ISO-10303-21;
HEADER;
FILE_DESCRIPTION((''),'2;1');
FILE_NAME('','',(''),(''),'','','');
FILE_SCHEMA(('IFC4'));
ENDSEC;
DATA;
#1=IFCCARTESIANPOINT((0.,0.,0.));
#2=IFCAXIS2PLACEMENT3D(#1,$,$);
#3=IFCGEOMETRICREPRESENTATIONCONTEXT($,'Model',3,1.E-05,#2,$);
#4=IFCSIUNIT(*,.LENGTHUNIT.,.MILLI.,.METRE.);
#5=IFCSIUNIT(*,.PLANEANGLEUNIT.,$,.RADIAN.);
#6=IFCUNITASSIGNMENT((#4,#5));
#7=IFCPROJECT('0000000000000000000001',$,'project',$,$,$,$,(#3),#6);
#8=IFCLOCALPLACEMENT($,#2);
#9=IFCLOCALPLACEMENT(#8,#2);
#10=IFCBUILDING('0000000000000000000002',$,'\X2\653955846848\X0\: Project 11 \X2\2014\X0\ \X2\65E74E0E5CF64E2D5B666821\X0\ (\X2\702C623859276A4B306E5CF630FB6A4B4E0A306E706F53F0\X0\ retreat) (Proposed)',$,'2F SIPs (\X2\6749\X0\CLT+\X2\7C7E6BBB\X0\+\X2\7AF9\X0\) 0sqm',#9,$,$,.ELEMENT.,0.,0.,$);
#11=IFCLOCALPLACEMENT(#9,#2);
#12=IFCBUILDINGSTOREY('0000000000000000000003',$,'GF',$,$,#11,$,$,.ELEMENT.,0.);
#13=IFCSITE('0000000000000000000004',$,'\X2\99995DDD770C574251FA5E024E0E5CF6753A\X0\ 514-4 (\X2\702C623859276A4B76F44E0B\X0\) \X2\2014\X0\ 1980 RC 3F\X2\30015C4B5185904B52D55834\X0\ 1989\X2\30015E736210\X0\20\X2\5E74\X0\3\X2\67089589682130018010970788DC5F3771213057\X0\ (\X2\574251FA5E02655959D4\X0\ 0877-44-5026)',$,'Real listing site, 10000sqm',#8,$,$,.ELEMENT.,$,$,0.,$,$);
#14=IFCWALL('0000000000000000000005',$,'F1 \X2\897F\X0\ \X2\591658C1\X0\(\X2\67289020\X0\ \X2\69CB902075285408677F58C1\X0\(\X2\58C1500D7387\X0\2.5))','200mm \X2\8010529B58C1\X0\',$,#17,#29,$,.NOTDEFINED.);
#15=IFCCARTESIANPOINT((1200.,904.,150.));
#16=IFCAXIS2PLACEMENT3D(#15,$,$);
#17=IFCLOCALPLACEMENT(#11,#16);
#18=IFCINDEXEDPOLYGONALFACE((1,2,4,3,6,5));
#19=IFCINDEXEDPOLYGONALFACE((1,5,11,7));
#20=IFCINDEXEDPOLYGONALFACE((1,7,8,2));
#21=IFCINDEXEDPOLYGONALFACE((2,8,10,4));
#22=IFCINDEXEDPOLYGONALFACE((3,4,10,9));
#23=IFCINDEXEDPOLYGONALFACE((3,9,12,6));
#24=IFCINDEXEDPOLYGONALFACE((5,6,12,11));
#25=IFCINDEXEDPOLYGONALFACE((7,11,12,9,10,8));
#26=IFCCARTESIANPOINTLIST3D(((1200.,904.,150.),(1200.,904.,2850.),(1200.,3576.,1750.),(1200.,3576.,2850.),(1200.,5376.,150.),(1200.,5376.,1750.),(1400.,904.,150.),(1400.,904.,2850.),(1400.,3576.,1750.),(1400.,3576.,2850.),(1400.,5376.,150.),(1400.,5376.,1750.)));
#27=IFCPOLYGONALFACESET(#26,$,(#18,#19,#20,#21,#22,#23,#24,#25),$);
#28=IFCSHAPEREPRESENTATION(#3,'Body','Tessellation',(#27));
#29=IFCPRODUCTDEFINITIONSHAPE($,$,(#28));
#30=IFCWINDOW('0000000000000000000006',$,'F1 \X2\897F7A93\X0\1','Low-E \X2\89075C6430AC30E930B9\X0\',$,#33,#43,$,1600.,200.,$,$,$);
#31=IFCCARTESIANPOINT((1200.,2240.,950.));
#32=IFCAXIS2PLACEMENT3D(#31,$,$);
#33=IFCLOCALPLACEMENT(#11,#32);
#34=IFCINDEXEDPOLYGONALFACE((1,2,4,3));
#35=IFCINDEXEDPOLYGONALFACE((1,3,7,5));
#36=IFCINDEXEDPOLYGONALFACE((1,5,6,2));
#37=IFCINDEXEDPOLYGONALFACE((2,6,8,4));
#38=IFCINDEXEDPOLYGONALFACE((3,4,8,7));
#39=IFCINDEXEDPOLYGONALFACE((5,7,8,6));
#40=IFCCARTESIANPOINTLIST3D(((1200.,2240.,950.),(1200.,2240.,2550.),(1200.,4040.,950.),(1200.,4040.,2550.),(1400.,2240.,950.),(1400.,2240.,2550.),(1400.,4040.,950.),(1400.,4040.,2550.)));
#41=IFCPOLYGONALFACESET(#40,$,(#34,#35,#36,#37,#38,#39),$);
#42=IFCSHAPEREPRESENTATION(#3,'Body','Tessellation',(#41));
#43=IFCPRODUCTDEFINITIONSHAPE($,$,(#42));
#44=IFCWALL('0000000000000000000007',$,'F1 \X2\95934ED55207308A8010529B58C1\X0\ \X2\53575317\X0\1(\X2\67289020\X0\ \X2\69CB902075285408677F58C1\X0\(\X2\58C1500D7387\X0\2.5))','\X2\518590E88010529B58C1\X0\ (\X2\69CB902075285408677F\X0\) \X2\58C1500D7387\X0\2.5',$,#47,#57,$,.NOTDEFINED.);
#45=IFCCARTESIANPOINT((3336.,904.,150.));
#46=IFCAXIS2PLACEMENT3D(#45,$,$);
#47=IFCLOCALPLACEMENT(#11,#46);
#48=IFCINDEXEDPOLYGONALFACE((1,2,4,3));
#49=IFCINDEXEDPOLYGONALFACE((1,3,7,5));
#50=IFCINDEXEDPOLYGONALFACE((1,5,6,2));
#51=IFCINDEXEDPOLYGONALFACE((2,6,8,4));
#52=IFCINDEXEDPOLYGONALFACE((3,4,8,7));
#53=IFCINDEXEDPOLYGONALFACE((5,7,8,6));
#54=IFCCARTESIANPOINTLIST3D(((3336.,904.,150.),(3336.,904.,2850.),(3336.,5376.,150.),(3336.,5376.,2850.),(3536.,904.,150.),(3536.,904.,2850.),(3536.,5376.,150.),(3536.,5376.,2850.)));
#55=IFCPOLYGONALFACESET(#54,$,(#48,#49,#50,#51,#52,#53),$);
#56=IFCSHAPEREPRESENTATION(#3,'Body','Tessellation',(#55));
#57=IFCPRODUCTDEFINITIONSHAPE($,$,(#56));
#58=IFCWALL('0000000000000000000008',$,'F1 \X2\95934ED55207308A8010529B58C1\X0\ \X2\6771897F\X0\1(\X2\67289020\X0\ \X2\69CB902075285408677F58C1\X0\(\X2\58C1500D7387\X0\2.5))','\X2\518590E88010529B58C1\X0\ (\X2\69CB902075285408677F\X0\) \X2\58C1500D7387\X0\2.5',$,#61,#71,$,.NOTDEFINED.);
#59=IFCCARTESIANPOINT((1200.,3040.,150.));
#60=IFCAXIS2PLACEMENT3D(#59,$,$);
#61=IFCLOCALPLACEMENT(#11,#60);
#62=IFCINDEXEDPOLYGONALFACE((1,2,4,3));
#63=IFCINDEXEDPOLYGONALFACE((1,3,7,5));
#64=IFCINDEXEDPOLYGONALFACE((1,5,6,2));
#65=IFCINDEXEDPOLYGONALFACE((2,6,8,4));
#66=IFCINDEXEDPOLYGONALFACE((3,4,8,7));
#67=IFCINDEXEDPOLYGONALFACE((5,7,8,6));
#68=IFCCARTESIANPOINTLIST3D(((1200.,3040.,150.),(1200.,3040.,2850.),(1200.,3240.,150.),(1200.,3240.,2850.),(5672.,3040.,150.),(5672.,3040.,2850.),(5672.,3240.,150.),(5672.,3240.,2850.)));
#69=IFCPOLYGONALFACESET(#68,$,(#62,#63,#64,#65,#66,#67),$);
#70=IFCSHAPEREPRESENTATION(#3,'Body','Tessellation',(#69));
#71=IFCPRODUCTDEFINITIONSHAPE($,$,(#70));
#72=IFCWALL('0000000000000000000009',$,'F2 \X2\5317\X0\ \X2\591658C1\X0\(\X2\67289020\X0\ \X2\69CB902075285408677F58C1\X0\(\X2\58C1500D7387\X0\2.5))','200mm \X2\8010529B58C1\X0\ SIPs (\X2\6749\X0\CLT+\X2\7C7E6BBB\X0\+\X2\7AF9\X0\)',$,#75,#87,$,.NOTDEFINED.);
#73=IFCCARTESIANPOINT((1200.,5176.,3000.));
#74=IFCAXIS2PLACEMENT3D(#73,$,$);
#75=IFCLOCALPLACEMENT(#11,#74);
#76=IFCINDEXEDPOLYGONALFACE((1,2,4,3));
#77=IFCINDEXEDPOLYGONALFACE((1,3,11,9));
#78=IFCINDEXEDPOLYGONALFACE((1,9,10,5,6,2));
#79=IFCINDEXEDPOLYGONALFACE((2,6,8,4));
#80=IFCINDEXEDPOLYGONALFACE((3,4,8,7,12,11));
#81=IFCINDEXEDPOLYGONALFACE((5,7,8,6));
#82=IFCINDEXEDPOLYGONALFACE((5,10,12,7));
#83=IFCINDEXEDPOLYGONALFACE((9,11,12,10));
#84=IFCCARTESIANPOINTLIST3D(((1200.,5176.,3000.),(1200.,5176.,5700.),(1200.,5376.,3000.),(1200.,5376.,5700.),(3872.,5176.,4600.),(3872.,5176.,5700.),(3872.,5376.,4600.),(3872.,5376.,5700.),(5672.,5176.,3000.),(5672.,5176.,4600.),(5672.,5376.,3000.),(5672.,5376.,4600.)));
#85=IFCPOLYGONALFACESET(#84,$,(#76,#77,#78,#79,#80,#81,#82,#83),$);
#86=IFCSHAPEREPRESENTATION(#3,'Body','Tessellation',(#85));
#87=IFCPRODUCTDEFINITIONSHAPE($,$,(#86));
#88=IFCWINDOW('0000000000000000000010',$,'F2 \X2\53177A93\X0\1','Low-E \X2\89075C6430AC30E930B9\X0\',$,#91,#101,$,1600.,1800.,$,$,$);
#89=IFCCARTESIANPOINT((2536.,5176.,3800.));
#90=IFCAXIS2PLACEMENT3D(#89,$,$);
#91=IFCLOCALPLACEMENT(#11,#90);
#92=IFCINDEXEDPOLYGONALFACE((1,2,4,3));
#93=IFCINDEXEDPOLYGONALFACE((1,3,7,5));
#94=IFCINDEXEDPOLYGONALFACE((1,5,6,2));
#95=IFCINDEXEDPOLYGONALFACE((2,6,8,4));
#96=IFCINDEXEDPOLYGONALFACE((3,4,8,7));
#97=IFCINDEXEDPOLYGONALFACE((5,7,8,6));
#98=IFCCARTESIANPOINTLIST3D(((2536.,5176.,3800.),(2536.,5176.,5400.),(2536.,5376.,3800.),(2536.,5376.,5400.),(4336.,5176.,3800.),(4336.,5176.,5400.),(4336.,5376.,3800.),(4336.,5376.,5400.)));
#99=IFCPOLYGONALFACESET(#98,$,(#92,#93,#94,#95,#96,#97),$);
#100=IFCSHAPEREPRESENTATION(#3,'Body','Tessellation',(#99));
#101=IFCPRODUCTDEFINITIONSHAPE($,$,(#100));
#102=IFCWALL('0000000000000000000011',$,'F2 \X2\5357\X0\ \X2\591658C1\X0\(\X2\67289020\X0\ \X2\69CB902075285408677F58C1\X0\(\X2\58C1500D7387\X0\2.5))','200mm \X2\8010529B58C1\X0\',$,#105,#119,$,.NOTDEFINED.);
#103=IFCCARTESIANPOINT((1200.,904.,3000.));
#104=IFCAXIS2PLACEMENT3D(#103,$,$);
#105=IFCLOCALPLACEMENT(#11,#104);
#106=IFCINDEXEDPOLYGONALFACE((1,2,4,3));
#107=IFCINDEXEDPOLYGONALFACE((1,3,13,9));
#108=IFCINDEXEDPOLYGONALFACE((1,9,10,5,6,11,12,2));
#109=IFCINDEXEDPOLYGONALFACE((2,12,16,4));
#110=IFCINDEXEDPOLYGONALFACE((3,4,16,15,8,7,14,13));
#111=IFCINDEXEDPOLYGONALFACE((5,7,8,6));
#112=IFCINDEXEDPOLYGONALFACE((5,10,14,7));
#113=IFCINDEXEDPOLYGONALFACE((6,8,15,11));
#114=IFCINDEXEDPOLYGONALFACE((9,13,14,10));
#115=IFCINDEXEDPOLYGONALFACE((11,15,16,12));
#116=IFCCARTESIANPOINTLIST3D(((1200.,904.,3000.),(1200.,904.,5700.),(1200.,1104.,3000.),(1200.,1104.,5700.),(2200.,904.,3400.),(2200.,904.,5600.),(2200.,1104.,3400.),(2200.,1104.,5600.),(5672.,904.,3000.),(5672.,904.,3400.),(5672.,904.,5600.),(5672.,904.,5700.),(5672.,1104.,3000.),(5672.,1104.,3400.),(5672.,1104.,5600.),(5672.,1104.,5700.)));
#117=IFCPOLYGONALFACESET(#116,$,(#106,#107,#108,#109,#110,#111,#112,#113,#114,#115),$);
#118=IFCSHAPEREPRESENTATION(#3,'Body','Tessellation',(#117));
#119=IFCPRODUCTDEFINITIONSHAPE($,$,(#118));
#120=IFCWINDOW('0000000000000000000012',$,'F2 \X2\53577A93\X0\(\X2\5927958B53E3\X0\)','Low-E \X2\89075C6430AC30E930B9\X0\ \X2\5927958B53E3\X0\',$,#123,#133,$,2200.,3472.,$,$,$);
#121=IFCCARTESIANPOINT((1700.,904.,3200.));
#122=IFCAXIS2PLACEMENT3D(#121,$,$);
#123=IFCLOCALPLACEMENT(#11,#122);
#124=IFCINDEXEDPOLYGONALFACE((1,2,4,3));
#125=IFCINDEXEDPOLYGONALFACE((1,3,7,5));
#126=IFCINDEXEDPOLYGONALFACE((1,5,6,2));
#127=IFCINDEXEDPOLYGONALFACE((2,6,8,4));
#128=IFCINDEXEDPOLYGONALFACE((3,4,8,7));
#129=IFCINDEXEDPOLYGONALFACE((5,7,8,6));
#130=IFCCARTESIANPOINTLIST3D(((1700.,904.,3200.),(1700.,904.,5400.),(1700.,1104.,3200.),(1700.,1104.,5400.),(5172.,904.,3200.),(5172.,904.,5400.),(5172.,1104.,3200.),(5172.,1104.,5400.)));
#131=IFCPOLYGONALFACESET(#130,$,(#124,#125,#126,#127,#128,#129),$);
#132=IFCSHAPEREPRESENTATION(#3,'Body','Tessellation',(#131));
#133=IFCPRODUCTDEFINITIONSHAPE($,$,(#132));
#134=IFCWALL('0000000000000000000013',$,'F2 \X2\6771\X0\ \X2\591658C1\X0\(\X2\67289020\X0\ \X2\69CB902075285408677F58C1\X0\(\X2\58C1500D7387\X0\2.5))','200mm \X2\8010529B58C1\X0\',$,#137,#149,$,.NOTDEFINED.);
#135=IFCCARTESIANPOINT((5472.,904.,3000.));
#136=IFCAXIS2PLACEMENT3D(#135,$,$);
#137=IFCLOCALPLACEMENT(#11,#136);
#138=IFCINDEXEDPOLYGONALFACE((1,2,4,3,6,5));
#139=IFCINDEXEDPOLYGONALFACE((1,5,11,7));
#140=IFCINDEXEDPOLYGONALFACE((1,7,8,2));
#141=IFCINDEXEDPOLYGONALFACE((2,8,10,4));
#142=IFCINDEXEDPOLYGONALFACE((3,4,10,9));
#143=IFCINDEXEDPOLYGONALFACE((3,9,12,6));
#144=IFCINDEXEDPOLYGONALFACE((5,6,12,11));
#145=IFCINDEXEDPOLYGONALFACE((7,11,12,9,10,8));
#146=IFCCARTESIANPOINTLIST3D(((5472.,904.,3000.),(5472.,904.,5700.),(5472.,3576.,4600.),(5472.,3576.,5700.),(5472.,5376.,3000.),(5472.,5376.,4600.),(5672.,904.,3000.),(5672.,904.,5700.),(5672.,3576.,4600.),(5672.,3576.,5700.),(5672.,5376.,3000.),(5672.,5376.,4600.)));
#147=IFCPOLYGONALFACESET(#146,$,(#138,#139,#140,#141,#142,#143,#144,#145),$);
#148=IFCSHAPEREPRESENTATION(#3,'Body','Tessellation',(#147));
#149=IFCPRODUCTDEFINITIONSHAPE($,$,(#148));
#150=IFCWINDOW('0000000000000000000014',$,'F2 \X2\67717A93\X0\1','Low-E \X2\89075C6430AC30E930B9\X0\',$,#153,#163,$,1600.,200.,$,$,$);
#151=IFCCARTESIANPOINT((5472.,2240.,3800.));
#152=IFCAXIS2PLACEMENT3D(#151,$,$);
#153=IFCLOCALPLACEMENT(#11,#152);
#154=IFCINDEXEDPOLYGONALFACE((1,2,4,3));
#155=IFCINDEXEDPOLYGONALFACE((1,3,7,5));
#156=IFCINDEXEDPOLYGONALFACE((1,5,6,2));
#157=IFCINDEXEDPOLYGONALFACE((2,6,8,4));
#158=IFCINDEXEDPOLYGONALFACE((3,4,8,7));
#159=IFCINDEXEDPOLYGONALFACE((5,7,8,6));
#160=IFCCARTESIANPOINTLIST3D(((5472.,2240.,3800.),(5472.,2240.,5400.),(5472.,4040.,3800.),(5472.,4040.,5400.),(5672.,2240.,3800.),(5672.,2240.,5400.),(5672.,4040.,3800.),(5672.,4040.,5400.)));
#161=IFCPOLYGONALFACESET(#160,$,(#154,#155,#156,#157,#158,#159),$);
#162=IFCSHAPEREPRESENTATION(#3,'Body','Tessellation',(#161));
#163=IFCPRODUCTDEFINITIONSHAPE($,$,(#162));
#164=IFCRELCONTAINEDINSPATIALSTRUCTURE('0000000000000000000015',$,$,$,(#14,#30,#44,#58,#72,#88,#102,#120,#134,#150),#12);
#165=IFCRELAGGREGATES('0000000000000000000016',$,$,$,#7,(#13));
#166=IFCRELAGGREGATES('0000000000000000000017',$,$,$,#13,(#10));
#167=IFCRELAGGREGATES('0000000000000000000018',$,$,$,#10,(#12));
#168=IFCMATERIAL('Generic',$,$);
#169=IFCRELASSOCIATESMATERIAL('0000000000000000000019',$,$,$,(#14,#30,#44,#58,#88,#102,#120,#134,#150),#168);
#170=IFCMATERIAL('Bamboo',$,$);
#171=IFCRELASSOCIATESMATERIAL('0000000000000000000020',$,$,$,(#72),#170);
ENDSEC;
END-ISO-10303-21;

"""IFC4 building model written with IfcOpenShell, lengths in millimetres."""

from ifc_helpers import new_model, si_unit, frame, frame_2d, origin, place, context, project, spatial, rectangle, extrude, material, element, fill, save


model = new_model("IFC4")

# Units and contexts
model_context = context("Model", 3, precision=1e-05, world=origin())
ifc_project = project(units=[si_unit("LENGTHUNIT", "METRE", prefix="MILLI"), si_unit("PLANEANGLEUNIT", "RADIAN")], contexts=[model_context])

# Site, building, storey
site_placement = place(None, origin())
site = spatial("IfcSite", under=ifc_project, at=site_placement, Name="香川県坂出市与島町 514-4 (瀬戸大橋直下) — 1980 RC 3F、屋内運動場 1989、平成20年3月閉校、耐震補強無し (坂出市教委 0877-44-5026)", ObjectType="Real listing site, 10000sqm", CompositionType="ELEMENT", RefElevation=0.0)
building_placement = place(site_placement, origin())
building = spatial("IfcBuilding", under=site, at=building_placement, Name="改善案: Project 11 — 旧与島中学校 (瀬戸大橋の島・橋上の灯台 retreat) (Proposed)", ObjectType="2F SIPs (杉CLT+籾殻+竹) 0sqm", CompositionType="ELEMENT", ElevationOfRefHeight=0.0, ElevationOfTerrain=0.0)
storey_placement = place(building_placement, origin())
storey = spatial("IfcBuildingStorey", under=building, at=storey_placement, Name="GF", CompositionType="ELEMENT", Elevation=0.0)

# Shared definitions
ifc_material_1 = material(Name="Generic")

# Shared definitions
ifc_material_2 = material(Name="Bamboo")

# Wall, opening, window
wall_1_placement = place(storey_placement, frame((1200.0, 904.0, 150.0)))
wall_1 = element("IfcWall", 1, at=wall_1_placement, inside=storey, material=ifc_material_1, Name="F1 西 外壁(木造 構造用合板壁(壁倍率2.5))", Description="200mm 耐力壁", PredefinedType="NOTDEFINED", context=model_context, shape_type="SweptSolid", body=[
    extrude(rectangle(XDim=200.0, YDim=4472.0, at=frame_2d((100.0, 2236.0))), frame((1200.0, 904.0, 150.0)), (0.0, 0.0, 1.0), 2700.0),
])
opening_1_placement = place(storey_placement, frame((1200.0, 2240.0, 950.0)))
opening_1 = element("IfcOpeningElement", 2, at=opening_1_placement, cuts=wall_1, PredefinedType="NOTDEFINED", context=model_context, shape_type="SweptSolid", body=[
    extrude(rectangle(XDim=200.0, YDim=1800.0, at=frame_2d((100.0, 900.0))), frame((1200.0, 2240.0, 950.0)), (0.0, 0.0, 1.0), 1600.0),
])
window_1_placement = place(storey_placement, frame((1200.0, 2240.0, 950.0)))
window_1 = element("IfcWindow", 3, at=window_1_placement, inside=storey, material=ifc_material_1, Name="F1 西窓1", Description="Low-E 複層ガラス", OverallHeight=1600.0, OverallWidth=200.0, context=model_context, shape_type="SweptSolid", body=[
    extrude(rectangle(XDim=200.0, YDim=1800.0, at=frame_2d((100.0, 900.0))), frame((1200.0, 2240.0, 950.0)), (0.0, 0.0, 1.0), 1600.0),
])
fill(opening_1, window_1)

# Walls
wall_2_placement = place(storey_placement, frame((3336.0, 904.0, 150.0)))
element("IfcWall", 4, at=wall_2_placement, inside=storey, material=ifc_material_1, Name="F1 間仕切り耐力壁 南北1(木造 構造用合板壁(壁倍率2.5))", Description="内部耐力壁 (構造用合板) 壁倍率2.5", PredefinedType="NOTDEFINED", context=model_context, shape_type="SweptSolid", body=[
    extrude(rectangle(XDim=200.0, YDim=4472.0, at=frame_2d((100.0, 2236.0))), frame((3336.0, 904.0, 150.0)), (0.0, 0.0, 1.0), 2700.0),
])
wall_3_placement = place(storey_placement, frame((1200.0, 3040.0, 150.0)))
element("IfcWall", 5, at=wall_3_placement, inside=storey, material=ifc_material_1, Name="F1 間仕切り耐力壁 東西1(木造 構造用合板壁(壁倍率2.5))", Description="内部耐力壁 (構造用合板) 壁倍率2.5", PredefinedType="NOTDEFINED", context=model_context, shape_type="SweptSolid", body=[
    extrude(rectangle(XDim=4472.0, YDim=200.0, at=frame_2d((2236.0, 100.0))), frame((1200.0, 3040.0, 150.0)), (0.0, 0.0, 1.0), 2700.0),
])

# Walls, openings, windows
wall_4_placement = place(storey_placement, frame((1200.0, 5176.0, 3000.0)))
wall_4 = element("IfcWall", 6, at=wall_4_placement, inside=storey, material=ifc_material_2, Name="F2 北 外壁(木造 構造用合板壁(壁倍率2.5))", Description="200mm 耐力壁 SIPs (杉CLT+籾殻+竹)", PredefinedType="NOTDEFINED", context=model_context, shape_type="SweptSolid", body=[
    extrude(rectangle(XDim=4472.0, YDim=200.0, at=frame_2d((2236.0, 100.0))), frame((1200.0, 5176.0, 3000.0)), (0.0, 0.0, 1.0), 2700.0),
])
opening_2_placement = place(storey_placement, frame((2536.0, 5176.0, 3800.0)))
opening_2 = element("IfcOpeningElement", 7, at=opening_2_placement, cuts=wall_4, PredefinedType="NOTDEFINED", context=model_context, shape_type="SweptSolid", body=[
    extrude(rectangle(XDim=1800.0, YDim=200.0, at=frame_2d((900.0, 100.0))), frame((2536.0, 5176.0, 3800.0)), (0.0, 0.0, 1.0), 1600.0),
])
window_2_placement = place(storey_placement, frame((2536.0, 5176.0, 3800.0)))
window_2 = element("IfcWindow", 8, at=window_2_placement, inside=storey, material=ifc_material_1, Name="F2 北窓1", Description="Low-E 複層ガラス", OverallHeight=1600.0, OverallWidth=1800.0, context=model_context, shape_type="SweptSolid", body=[
    extrude(rectangle(XDim=1800.0, YDim=200.0, at=frame_2d((900.0, 100.0))), frame((2536.0, 5176.0, 3800.0)), (0.0, 0.0, 1.0), 1600.0),
])
fill(opening_2, window_2)
wall_5_placement = place(storey_placement, frame((1200.0, 904.0, 3000.0)))
wall_5 = element("IfcWall", 9, at=wall_5_placement, inside=storey, material=ifc_material_1, Name="F2 南 外壁(木造 構造用合板壁(壁倍率2.5))", Description="200mm 耐力壁", PredefinedType="NOTDEFINED", context=model_context, shape_type="SweptSolid", body=[
    extrude(rectangle(XDim=4472.0, YDim=200.0, at=frame_2d((2236.0, 100.0))), frame((1200.0, 904.0, 3000.0)), (0.0, 0.0, 1.0), 2700.0),
])
opening_3_placement = place(storey_placement, frame((1700.0, 904.0, 3200.0)))
opening_3 = element("IfcOpeningElement", 10, at=opening_3_placement, cuts=wall_5, PredefinedType="NOTDEFINED", context=model_context, shape_type="SweptSolid", body=[
    extrude(rectangle(XDim=3472.0, YDim=200.0, at=frame_2d((1736.0, 100.0))), frame((1700.0, 904.0, 3200.0)), (0.0, 0.0, 1.0), 2200.0),
])
window_3_placement = place(storey_placement, frame((1700.0, 904.0, 3200.0)))
window_3 = element("IfcWindow", 11, at=window_3_placement, inside=storey, material=ifc_material_1, Name="F2 南窓(大開口)", Description="Low-E 複層ガラス 大開口", OverallHeight=2200.0, OverallWidth=3472.0, context=model_context, shape_type="SweptSolid", body=[
    extrude(rectangle(XDim=3472.0, YDim=200.0, at=frame_2d((1736.0, 100.0))), frame((1700.0, 904.0, 3200.0)), (0.0, 0.0, 1.0), 2200.0),
])
fill(opening_3, window_3)
wall_6_placement = place(storey_placement, frame((5472.0, 904.0, 3000.0)))
wall_6 = element("IfcWall", 12, at=wall_6_placement, inside=storey, material=ifc_material_1, Name="F2 東 外壁(木造 構造用合板壁(壁倍率2.5))", Description="200mm 耐力壁", PredefinedType="NOTDEFINED", context=model_context, shape_type="SweptSolid", body=[
    extrude(rectangle(XDim=200.0, YDim=4472.0, at=frame_2d((100.0, 2236.0))), frame((5472.0, 904.0, 3000.0)), (0.0, 0.0, 1.0), 2700.0),
])
opening_4_placement = place(storey_placement, frame((5472.0, 2240.0, 3800.0)))
opening_4 = element("IfcOpeningElement", 13, at=opening_4_placement, cuts=wall_6, PredefinedType="NOTDEFINED", context=model_context, shape_type="SweptSolid", body=[
    extrude(rectangle(XDim=200.0, YDim=1800.0, at=frame_2d((100.0, 900.0))), frame((5472.0, 2240.0, 3800.0)), (0.0, 0.0, 1.0), 1600.0),
])
window_4_placement = place(storey_placement, frame((5472.0, 2240.0, 3800.0)))
window_4 = element("IfcWindow", 14, at=window_4_placement, inside=storey, material=ifc_material_1, Name="F2 東窓1", Description="Low-E 複層ガラス", OverallHeight=1600.0, OverallWidth=200.0, context=model_context, shape_type="SweptSolid", body=[
    extrude(rectangle(XDim=200.0, YDim=1800.0, at=frame_2d((100.0, 900.0))), frame((5472.0, 2240.0, 3800.0)), (0.0, 0.0, 1.0), 1600.0),
])
fill(opening_4, window_4)

save(model, "model.ifc")
